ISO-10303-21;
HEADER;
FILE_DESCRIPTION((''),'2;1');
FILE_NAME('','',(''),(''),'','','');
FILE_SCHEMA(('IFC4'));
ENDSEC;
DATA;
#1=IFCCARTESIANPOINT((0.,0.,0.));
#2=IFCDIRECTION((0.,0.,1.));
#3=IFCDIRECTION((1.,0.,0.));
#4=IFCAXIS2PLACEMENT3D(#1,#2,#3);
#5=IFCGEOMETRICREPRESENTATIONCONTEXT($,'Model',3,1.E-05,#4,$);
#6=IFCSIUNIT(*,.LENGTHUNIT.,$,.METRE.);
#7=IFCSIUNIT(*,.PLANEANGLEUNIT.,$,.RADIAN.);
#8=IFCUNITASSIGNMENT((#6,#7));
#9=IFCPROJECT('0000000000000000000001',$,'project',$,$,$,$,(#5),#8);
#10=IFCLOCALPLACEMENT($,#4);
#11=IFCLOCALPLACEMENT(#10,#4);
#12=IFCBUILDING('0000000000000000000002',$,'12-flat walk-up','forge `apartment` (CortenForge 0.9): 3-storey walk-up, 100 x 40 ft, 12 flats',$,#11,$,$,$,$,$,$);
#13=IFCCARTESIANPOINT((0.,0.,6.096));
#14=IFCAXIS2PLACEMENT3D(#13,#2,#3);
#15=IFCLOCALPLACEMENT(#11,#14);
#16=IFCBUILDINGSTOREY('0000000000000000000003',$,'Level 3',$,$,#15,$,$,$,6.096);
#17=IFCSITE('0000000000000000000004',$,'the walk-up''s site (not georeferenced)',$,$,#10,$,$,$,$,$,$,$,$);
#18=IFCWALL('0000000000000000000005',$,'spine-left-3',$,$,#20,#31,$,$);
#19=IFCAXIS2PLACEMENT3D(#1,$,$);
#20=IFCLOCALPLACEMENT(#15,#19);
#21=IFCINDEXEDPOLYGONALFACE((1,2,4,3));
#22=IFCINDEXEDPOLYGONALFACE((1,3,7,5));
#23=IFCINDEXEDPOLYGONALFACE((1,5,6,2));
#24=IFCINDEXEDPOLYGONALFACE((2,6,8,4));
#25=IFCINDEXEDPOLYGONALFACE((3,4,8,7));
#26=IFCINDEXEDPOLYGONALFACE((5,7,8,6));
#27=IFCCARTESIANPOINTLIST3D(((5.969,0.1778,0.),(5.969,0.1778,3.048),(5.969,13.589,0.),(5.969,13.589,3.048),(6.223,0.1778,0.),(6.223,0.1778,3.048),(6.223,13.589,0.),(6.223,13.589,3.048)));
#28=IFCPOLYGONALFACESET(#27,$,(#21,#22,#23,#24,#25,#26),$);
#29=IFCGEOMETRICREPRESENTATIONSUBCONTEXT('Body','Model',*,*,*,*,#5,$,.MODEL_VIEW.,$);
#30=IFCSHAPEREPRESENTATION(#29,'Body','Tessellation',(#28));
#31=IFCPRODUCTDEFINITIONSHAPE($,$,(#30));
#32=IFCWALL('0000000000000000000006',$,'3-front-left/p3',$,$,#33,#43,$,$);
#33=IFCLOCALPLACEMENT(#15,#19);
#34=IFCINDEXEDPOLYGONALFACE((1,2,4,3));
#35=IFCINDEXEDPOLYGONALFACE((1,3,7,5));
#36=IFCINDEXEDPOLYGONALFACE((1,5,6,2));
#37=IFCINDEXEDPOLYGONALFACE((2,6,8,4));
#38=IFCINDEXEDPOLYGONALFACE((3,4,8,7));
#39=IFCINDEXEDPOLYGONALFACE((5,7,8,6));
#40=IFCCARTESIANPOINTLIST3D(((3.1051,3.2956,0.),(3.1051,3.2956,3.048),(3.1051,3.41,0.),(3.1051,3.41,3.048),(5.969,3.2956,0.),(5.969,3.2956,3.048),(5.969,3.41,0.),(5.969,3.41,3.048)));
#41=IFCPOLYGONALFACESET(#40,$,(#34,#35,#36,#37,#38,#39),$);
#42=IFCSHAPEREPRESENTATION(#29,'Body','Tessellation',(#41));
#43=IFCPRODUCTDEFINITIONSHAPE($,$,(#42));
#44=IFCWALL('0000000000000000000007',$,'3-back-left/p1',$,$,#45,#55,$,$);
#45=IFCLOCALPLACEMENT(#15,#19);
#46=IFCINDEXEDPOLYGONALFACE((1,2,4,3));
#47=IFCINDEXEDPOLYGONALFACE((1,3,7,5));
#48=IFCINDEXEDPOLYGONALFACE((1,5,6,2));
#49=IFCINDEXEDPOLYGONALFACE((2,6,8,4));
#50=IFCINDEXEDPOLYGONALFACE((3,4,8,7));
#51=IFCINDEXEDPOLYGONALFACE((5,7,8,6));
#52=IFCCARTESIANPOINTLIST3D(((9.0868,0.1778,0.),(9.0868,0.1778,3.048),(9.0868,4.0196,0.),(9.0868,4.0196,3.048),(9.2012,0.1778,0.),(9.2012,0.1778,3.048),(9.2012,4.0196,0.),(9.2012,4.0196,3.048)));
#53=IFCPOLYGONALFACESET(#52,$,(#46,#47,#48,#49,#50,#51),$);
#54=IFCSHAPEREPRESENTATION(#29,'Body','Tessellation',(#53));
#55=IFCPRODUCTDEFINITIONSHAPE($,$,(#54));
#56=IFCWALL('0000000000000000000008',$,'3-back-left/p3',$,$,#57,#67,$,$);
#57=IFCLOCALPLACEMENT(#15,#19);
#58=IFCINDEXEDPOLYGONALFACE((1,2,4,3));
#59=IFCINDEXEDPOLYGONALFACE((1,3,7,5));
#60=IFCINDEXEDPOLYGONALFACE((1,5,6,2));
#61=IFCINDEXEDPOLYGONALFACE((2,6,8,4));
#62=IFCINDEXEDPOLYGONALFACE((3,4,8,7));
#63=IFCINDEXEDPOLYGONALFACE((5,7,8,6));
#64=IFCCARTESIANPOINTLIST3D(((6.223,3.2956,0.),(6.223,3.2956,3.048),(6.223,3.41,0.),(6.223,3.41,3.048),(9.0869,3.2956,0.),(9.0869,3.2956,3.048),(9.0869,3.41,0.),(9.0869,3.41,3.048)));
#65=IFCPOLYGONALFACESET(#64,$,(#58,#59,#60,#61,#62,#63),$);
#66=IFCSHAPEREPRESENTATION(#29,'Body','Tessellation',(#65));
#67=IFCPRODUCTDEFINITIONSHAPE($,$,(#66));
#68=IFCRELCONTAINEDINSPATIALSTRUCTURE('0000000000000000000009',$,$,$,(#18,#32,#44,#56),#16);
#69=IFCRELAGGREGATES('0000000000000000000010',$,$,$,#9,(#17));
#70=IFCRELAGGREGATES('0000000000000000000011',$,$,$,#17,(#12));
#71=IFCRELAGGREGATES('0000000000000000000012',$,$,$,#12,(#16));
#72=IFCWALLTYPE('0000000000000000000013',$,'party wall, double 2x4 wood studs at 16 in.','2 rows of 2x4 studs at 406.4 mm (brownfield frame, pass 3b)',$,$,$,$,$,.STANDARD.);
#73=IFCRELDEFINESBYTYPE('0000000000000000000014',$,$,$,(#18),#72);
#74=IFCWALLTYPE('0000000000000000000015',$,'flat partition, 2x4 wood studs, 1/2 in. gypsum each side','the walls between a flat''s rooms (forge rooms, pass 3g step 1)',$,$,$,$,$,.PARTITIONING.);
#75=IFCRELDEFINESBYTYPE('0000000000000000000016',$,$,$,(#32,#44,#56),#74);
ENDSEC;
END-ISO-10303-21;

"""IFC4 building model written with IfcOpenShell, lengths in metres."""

from ifc_helpers import new_model, si_unit, frame, frame_2d, origin, origin_with_axes, place, context, subcontext, project, spatial, rectangle, extrude, type_object, element, save


model = new_model("IFC4")

# Units and contexts
model_context = context("Model", 3, precision=1e-05, world=origin_with_axes())
body_context = subcontext(model_context, "Body", "Model", "MODEL_VIEW")
ifc_project = project(units=[si_unit("LENGTHUNIT", "METRE"), si_unit("PLANEANGLEUNIT", "RADIAN")], contexts=[model_context])

# Site, building, storey
site_placement = place(None, origin_with_axes())
site = spatial("IfcSite", under=ifc_project, at=site_placement, Name="the walk-up's site (not georeferenced)")
building_placement = place(site_placement, origin_with_axes())
building = spatial("IfcBuilding", under=site, at=building_placement, Name="12-flat walk-up", Description="forge `apartment` (CortenForge 0.9): 3-storey walk-up, 100 x 40 ft, 12 flats")
storey_placement = place(building_placement, frame((0.0, 0.0, 6.096), z_axis=(0.0, 0.0, 1.0), x_axis=(1.0, 0.0, 0.0)))
storey = spatial("IfcBuildingStorey", under=building, at=storey_placement, Name="Level 3", Elevation=6.096)

# Walls
wall_type_1 = type_object("IfcWallType", Name="party wall, double 2x4 wood studs at 16 in.", Description="2 rows of 2x4 studs at 406.4 mm (brownfield frame, pass 3b)", PredefinedType="STANDARD")
wall_1_placement = place(storey_placement, frame((5.969, 0.1778, 0.0), z_axis=(0.0, 0.0, 1.0), x_axis=(1.0, 0.0, 0.0)))
element("IfcWall", 1, at=wall_1_placement, inside=storey, type_object=wall_type_1, Name="spine-left-3", context=body_context, shape_type="SweptSolid", body=[
    extrude(rectangle(XDim=0.254, YDim=13.4112, at=frame_2d((0.127, 6.7056))), origin(), (0.0, 0.0, 1.0), 3.048),
])
wall_type_2 = type_object("IfcWallType", Name="flat partition, 2x4 wood studs, 1/2 in. gypsum each side", Description="the walls between a flat's rooms (forge rooms, pass 3g step 1)", PredefinedType="PARTITIONING")
wall_2_placement = place(storey_placement, frame((3.1051, 3.2957, 0.0), z_axis=(0.0, 0.0, 1.0), x_axis=(1.0, 0.0, 0.0)))
element("IfcWall", 2, at=wall_2_placement, inside=storey, type_object=wall_type_2, Name="3-front-left/p3", context=body_context, shape_type="SweptSolid", body=[
    extrude(rectangle(XDim=2.8639, YDim=0.1143, at=frame_2d((1.4319, 0.0571))), origin(), (0.0, 0.0, 1.0), 3.048),
])
wall_3_placement = place(storey_placement, frame((9.0869, 0.1778, 0.0), z_axis=(0.0, 0.0, 1.0), x_axis=(1.0, 0.0, 0.0)))
element("IfcWall", 3, at=wall_3_placement, inside=storey, type_object=wall_type_2, Name="3-back-left/p1", context=body_context, shape_type="SweptSolid", body=[
    extrude(rectangle(XDim=0.1143, YDim=3.8417, at=frame_2d((0.0572, 1.9209))), origin(), (0.0, 0.0, 1.0), 3.048),
])
wall_4_placement = place(storey_placement, frame((6.223, 3.2957, 0.0), z_axis=(0.0, 0.0, 1.0), x_axis=(1.0, 0.0, 0.0)))
element("IfcWall", 4, at=wall_4_placement, inside=storey, type_object=wall_type_2, Name="3-back-left/p3", context=body_context, shape_type="SweptSolid", body=[
    extrude(rectangle(XDim=2.8639, YDim=0.1143, at=frame_2d((1.4319, 0.0571))), origin(), (0.0, 0.0, 1.0), 3.048),
])

save(model, "model.ifc")
